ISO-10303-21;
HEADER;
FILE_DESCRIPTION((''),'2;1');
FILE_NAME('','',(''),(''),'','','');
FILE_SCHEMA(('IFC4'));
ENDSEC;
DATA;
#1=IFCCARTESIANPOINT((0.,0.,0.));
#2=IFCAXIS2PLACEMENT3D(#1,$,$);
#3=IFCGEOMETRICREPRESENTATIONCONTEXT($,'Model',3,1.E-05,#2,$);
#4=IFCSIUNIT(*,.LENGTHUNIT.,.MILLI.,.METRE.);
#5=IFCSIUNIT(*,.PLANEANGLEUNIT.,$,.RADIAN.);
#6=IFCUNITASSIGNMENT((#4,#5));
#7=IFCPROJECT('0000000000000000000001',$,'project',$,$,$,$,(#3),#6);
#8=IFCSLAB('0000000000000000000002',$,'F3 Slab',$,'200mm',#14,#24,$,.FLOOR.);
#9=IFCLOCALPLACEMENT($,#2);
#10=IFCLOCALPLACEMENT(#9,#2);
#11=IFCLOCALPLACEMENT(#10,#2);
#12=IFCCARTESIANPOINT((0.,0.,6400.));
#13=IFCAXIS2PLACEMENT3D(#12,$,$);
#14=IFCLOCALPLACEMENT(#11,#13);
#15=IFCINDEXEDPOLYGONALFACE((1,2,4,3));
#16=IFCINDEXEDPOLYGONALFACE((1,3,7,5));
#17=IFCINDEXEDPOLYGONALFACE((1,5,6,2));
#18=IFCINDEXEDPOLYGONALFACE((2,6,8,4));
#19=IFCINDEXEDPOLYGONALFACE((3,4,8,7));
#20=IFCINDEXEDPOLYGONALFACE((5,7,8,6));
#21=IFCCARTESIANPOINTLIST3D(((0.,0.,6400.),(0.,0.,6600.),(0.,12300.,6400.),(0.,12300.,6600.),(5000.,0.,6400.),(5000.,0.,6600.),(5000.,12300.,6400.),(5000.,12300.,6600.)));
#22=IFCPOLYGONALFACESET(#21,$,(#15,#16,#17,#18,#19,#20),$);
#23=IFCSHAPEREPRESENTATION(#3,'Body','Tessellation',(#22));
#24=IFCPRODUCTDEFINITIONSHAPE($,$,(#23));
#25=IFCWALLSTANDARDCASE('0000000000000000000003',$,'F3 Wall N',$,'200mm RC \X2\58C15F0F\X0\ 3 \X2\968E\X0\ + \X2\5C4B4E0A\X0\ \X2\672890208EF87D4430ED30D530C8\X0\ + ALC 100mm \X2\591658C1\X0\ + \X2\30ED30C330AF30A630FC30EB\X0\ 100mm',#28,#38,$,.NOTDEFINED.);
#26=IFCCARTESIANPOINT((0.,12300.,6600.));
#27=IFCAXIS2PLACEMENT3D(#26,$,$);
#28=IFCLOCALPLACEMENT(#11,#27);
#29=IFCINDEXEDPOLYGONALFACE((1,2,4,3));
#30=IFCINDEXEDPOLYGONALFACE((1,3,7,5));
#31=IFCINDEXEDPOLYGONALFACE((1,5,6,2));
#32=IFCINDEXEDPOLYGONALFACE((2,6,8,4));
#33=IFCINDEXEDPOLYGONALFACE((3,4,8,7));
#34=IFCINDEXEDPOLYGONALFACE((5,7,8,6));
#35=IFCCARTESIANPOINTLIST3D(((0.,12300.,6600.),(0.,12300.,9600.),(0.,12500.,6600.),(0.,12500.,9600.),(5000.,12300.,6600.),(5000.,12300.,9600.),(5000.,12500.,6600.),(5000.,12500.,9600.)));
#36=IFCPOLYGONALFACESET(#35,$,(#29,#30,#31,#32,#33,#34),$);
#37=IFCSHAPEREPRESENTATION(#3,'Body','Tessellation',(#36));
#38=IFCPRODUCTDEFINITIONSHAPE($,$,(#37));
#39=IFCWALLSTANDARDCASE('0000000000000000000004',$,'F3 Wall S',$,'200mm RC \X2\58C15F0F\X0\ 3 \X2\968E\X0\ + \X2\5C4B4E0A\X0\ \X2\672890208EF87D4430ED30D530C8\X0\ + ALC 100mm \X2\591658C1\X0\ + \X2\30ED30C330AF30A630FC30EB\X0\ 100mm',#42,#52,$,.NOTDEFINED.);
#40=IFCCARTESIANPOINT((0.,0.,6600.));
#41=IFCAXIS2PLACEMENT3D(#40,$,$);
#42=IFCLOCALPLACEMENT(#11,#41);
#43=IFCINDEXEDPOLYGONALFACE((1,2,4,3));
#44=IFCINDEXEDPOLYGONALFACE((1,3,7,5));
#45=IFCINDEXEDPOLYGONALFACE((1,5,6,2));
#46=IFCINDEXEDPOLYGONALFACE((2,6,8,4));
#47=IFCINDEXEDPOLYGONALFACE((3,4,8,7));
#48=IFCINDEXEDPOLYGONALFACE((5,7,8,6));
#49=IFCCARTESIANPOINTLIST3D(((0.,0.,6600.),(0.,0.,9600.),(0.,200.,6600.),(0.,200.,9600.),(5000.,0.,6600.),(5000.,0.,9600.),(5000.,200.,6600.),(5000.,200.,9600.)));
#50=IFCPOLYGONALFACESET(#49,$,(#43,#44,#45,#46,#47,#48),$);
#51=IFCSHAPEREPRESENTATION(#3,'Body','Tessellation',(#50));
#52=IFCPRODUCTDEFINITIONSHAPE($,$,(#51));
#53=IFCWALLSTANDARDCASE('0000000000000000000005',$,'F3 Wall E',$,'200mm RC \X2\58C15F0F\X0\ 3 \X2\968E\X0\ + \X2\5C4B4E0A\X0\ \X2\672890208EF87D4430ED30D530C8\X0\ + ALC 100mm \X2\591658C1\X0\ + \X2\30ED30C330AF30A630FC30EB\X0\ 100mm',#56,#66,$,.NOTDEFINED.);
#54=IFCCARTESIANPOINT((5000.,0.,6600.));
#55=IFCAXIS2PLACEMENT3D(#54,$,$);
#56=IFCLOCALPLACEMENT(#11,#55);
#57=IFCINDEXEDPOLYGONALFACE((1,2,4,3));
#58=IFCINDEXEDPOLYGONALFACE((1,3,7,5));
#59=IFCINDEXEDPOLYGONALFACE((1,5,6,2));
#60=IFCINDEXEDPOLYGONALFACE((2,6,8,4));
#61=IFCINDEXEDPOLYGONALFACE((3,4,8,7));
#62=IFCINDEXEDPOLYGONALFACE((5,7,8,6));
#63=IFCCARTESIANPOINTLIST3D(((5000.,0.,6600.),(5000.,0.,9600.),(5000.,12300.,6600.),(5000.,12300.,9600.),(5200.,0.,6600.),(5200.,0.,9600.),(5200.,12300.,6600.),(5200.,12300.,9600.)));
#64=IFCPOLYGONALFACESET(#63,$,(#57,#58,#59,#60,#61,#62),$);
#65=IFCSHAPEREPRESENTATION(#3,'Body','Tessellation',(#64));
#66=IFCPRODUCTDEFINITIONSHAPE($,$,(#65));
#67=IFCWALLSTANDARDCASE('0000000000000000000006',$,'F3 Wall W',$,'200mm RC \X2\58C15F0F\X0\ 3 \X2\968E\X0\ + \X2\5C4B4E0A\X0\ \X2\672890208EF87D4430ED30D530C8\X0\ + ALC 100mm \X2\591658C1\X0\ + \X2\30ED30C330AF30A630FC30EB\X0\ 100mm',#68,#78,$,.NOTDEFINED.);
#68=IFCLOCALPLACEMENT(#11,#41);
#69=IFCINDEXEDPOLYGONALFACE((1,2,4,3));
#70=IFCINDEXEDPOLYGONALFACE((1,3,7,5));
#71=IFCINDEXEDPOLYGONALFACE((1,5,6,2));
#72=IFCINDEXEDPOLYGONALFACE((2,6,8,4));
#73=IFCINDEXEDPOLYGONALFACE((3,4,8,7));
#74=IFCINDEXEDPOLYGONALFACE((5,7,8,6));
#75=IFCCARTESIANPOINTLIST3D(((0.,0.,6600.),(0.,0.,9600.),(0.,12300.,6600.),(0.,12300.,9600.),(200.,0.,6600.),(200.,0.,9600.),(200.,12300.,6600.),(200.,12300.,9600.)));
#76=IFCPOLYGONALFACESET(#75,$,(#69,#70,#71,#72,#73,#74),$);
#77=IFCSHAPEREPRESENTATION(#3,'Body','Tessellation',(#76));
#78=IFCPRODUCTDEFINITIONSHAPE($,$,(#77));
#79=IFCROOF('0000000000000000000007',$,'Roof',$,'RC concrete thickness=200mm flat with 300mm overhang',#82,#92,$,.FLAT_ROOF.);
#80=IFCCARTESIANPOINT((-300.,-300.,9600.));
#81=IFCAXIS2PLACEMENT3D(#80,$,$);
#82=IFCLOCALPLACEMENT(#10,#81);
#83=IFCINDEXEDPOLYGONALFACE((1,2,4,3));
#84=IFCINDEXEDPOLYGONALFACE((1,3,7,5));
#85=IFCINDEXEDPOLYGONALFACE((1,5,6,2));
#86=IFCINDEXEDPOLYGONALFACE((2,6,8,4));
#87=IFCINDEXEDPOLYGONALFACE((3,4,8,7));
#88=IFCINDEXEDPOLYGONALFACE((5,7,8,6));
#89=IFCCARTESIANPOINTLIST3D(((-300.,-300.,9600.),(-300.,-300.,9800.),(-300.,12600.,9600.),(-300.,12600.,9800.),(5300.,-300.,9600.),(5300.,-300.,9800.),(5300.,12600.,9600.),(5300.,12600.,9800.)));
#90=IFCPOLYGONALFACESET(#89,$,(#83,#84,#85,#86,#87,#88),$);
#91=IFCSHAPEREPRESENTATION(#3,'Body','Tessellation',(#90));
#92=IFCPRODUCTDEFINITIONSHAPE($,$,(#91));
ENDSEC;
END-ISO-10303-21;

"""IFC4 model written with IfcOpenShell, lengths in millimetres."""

from ifc_helpers import new_model, si_unit, frame, frame_2d, origin, place, context, project, rectangle, extrude, element, save


model = new_model("IFC4")

# Units and contexts
model_context = context("Model", 3, precision=1e-05, world=origin())
ifc_project = project(units=[si_unit("LENGTHUNIT", "METRE", prefix="MILLI"), si_unit("PLANEANGLEUNIT", "RADIAN")], contexts=[model_context])

# Slab
placement_1 = place(None, origin())
placement_2 = place(placement_1, origin())
placement_3 = place(placement_2, origin())
slab_placement = place(placement_3, frame((0.0, 0.0, 6400.0)))
element("IfcSlab", 1, at=slab_placement, Name="F3 Slab", ObjectType="200mm", PredefinedType="FLOOR", context=model_context, shape_type="SweptSolid", body=[
    extrude(rectangle(XDim=5000.0, YDim=12300.0, at=frame_2d((2500.0, 6150.0))), frame((0.0, 0.0, 6400.0)), (0.0, 0.0, 1.0), 200.0),
])

# Walls
wall_1_placement = place(placement_3, frame((0.0, 12300.0, 6600.0)))
element("IfcWallStandardCase", 2, at=wall_1_placement, Name="F3 Wall N", ObjectType="200mm RC 壁式 3 階 + 屋上 木造軸組ロフト + ALC 100mm 外壁 + ロックウール 100mm", PredefinedType="NOTDEFINED", context=model_context, shape_type="SweptSolid", body=[
    extrude(rectangle(XDim=5000.0, YDim=200.0, at=frame_2d((2500.0, 100.0))), frame((0.0, 12300.0, 6600.0)), (0.0, 0.0, 1.0), 3000.0),
])
wall_2_placement = place(placement_3, frame((0.0, 0.0, 6600.0)))
element("IfcWallStandardCase", 3, at=wall_2_placement, Name="F3 Wall S", ObjectType="200mm RC 壁式 3 階 + 屋上 木造軸組ロフト + ALC 100mm 外壁 + ロックウール 100mm", PredefinedType="NOTDEFINED", context=model_context, shape_type="SweptSolid", body=[
    extrude(rectangle(XDim=5000.0, YDim=200.0, at=frame_2d((2500.0, 100.0))), frame((0.0, 0.0, 6600.0)), (0.0, 0.0, 1.0), 3000.0),
])
wall_3_placement = place(placement_3, frame((5000.0, 0.0, 6600.0)))
element("IfcWallStandardCase", 4, at=wall_3_placement, Name="F3 Wall E", ObjectType="200mm RC 壁式 3 階 + 屋上 木造軸組ロフト + ALC 100mm 外壁 + ロックウール 100mm", PredefinedType="NOTDEFINED", context=model_context, shape_type="SweptSolid", body=[
    extrude(rectangle(XDim=200.0, YDim=12300.0, at=frame_2d((100.0, 6150.0))), frame((5000.0, 0.0, 6600.0)), (0.0, 0.0, 1.0), 3000.0),
])
wall_4_placement = place(placement_3, frame((0.0, 0.0, 6600.0)))
element("IfcWallStandardCase", 5, at=wall_4_placement, Name="F3 Wall W", ObjectType="200mm RC 壁式 3 階 + 屋上 木造軸組ロフト + ALC 100mm 外壁 + ロックウール 100mm", PredefinedType="NOTDEFINED", context=model_context, shape_type="SweptSolid", body=[
    extrude(rectangle(XDim=200.0, YDim=12300.0, at=frame_2d((100.0, 6150.0))), frame((0.0, 0.0, 6600.0)), (0.0, 0.0, 1.0), 3000.0),
])

# Roof
roof_placement = place(placement_2, frame((-300.0, -300.0, 9600.0)))
element("IfcRoof", 6, at=roof_placement, Name="Roof", ObjectType="RC concrete thickness=200mm flat with 300mm overhang", PredefinedType="FLAT_ROOF", context=model_context, shape_type="SweptSolid", body=[
    extrude(rectangle(XDim=5600.0, YDim=12900.0, at=frame_2d((2800.0, 6450.0))), frame((-300.0, -300.0, 9600.0)), (0.0, 0.0, 1.0), 200.0),
])

save(model, "model.ifc")
